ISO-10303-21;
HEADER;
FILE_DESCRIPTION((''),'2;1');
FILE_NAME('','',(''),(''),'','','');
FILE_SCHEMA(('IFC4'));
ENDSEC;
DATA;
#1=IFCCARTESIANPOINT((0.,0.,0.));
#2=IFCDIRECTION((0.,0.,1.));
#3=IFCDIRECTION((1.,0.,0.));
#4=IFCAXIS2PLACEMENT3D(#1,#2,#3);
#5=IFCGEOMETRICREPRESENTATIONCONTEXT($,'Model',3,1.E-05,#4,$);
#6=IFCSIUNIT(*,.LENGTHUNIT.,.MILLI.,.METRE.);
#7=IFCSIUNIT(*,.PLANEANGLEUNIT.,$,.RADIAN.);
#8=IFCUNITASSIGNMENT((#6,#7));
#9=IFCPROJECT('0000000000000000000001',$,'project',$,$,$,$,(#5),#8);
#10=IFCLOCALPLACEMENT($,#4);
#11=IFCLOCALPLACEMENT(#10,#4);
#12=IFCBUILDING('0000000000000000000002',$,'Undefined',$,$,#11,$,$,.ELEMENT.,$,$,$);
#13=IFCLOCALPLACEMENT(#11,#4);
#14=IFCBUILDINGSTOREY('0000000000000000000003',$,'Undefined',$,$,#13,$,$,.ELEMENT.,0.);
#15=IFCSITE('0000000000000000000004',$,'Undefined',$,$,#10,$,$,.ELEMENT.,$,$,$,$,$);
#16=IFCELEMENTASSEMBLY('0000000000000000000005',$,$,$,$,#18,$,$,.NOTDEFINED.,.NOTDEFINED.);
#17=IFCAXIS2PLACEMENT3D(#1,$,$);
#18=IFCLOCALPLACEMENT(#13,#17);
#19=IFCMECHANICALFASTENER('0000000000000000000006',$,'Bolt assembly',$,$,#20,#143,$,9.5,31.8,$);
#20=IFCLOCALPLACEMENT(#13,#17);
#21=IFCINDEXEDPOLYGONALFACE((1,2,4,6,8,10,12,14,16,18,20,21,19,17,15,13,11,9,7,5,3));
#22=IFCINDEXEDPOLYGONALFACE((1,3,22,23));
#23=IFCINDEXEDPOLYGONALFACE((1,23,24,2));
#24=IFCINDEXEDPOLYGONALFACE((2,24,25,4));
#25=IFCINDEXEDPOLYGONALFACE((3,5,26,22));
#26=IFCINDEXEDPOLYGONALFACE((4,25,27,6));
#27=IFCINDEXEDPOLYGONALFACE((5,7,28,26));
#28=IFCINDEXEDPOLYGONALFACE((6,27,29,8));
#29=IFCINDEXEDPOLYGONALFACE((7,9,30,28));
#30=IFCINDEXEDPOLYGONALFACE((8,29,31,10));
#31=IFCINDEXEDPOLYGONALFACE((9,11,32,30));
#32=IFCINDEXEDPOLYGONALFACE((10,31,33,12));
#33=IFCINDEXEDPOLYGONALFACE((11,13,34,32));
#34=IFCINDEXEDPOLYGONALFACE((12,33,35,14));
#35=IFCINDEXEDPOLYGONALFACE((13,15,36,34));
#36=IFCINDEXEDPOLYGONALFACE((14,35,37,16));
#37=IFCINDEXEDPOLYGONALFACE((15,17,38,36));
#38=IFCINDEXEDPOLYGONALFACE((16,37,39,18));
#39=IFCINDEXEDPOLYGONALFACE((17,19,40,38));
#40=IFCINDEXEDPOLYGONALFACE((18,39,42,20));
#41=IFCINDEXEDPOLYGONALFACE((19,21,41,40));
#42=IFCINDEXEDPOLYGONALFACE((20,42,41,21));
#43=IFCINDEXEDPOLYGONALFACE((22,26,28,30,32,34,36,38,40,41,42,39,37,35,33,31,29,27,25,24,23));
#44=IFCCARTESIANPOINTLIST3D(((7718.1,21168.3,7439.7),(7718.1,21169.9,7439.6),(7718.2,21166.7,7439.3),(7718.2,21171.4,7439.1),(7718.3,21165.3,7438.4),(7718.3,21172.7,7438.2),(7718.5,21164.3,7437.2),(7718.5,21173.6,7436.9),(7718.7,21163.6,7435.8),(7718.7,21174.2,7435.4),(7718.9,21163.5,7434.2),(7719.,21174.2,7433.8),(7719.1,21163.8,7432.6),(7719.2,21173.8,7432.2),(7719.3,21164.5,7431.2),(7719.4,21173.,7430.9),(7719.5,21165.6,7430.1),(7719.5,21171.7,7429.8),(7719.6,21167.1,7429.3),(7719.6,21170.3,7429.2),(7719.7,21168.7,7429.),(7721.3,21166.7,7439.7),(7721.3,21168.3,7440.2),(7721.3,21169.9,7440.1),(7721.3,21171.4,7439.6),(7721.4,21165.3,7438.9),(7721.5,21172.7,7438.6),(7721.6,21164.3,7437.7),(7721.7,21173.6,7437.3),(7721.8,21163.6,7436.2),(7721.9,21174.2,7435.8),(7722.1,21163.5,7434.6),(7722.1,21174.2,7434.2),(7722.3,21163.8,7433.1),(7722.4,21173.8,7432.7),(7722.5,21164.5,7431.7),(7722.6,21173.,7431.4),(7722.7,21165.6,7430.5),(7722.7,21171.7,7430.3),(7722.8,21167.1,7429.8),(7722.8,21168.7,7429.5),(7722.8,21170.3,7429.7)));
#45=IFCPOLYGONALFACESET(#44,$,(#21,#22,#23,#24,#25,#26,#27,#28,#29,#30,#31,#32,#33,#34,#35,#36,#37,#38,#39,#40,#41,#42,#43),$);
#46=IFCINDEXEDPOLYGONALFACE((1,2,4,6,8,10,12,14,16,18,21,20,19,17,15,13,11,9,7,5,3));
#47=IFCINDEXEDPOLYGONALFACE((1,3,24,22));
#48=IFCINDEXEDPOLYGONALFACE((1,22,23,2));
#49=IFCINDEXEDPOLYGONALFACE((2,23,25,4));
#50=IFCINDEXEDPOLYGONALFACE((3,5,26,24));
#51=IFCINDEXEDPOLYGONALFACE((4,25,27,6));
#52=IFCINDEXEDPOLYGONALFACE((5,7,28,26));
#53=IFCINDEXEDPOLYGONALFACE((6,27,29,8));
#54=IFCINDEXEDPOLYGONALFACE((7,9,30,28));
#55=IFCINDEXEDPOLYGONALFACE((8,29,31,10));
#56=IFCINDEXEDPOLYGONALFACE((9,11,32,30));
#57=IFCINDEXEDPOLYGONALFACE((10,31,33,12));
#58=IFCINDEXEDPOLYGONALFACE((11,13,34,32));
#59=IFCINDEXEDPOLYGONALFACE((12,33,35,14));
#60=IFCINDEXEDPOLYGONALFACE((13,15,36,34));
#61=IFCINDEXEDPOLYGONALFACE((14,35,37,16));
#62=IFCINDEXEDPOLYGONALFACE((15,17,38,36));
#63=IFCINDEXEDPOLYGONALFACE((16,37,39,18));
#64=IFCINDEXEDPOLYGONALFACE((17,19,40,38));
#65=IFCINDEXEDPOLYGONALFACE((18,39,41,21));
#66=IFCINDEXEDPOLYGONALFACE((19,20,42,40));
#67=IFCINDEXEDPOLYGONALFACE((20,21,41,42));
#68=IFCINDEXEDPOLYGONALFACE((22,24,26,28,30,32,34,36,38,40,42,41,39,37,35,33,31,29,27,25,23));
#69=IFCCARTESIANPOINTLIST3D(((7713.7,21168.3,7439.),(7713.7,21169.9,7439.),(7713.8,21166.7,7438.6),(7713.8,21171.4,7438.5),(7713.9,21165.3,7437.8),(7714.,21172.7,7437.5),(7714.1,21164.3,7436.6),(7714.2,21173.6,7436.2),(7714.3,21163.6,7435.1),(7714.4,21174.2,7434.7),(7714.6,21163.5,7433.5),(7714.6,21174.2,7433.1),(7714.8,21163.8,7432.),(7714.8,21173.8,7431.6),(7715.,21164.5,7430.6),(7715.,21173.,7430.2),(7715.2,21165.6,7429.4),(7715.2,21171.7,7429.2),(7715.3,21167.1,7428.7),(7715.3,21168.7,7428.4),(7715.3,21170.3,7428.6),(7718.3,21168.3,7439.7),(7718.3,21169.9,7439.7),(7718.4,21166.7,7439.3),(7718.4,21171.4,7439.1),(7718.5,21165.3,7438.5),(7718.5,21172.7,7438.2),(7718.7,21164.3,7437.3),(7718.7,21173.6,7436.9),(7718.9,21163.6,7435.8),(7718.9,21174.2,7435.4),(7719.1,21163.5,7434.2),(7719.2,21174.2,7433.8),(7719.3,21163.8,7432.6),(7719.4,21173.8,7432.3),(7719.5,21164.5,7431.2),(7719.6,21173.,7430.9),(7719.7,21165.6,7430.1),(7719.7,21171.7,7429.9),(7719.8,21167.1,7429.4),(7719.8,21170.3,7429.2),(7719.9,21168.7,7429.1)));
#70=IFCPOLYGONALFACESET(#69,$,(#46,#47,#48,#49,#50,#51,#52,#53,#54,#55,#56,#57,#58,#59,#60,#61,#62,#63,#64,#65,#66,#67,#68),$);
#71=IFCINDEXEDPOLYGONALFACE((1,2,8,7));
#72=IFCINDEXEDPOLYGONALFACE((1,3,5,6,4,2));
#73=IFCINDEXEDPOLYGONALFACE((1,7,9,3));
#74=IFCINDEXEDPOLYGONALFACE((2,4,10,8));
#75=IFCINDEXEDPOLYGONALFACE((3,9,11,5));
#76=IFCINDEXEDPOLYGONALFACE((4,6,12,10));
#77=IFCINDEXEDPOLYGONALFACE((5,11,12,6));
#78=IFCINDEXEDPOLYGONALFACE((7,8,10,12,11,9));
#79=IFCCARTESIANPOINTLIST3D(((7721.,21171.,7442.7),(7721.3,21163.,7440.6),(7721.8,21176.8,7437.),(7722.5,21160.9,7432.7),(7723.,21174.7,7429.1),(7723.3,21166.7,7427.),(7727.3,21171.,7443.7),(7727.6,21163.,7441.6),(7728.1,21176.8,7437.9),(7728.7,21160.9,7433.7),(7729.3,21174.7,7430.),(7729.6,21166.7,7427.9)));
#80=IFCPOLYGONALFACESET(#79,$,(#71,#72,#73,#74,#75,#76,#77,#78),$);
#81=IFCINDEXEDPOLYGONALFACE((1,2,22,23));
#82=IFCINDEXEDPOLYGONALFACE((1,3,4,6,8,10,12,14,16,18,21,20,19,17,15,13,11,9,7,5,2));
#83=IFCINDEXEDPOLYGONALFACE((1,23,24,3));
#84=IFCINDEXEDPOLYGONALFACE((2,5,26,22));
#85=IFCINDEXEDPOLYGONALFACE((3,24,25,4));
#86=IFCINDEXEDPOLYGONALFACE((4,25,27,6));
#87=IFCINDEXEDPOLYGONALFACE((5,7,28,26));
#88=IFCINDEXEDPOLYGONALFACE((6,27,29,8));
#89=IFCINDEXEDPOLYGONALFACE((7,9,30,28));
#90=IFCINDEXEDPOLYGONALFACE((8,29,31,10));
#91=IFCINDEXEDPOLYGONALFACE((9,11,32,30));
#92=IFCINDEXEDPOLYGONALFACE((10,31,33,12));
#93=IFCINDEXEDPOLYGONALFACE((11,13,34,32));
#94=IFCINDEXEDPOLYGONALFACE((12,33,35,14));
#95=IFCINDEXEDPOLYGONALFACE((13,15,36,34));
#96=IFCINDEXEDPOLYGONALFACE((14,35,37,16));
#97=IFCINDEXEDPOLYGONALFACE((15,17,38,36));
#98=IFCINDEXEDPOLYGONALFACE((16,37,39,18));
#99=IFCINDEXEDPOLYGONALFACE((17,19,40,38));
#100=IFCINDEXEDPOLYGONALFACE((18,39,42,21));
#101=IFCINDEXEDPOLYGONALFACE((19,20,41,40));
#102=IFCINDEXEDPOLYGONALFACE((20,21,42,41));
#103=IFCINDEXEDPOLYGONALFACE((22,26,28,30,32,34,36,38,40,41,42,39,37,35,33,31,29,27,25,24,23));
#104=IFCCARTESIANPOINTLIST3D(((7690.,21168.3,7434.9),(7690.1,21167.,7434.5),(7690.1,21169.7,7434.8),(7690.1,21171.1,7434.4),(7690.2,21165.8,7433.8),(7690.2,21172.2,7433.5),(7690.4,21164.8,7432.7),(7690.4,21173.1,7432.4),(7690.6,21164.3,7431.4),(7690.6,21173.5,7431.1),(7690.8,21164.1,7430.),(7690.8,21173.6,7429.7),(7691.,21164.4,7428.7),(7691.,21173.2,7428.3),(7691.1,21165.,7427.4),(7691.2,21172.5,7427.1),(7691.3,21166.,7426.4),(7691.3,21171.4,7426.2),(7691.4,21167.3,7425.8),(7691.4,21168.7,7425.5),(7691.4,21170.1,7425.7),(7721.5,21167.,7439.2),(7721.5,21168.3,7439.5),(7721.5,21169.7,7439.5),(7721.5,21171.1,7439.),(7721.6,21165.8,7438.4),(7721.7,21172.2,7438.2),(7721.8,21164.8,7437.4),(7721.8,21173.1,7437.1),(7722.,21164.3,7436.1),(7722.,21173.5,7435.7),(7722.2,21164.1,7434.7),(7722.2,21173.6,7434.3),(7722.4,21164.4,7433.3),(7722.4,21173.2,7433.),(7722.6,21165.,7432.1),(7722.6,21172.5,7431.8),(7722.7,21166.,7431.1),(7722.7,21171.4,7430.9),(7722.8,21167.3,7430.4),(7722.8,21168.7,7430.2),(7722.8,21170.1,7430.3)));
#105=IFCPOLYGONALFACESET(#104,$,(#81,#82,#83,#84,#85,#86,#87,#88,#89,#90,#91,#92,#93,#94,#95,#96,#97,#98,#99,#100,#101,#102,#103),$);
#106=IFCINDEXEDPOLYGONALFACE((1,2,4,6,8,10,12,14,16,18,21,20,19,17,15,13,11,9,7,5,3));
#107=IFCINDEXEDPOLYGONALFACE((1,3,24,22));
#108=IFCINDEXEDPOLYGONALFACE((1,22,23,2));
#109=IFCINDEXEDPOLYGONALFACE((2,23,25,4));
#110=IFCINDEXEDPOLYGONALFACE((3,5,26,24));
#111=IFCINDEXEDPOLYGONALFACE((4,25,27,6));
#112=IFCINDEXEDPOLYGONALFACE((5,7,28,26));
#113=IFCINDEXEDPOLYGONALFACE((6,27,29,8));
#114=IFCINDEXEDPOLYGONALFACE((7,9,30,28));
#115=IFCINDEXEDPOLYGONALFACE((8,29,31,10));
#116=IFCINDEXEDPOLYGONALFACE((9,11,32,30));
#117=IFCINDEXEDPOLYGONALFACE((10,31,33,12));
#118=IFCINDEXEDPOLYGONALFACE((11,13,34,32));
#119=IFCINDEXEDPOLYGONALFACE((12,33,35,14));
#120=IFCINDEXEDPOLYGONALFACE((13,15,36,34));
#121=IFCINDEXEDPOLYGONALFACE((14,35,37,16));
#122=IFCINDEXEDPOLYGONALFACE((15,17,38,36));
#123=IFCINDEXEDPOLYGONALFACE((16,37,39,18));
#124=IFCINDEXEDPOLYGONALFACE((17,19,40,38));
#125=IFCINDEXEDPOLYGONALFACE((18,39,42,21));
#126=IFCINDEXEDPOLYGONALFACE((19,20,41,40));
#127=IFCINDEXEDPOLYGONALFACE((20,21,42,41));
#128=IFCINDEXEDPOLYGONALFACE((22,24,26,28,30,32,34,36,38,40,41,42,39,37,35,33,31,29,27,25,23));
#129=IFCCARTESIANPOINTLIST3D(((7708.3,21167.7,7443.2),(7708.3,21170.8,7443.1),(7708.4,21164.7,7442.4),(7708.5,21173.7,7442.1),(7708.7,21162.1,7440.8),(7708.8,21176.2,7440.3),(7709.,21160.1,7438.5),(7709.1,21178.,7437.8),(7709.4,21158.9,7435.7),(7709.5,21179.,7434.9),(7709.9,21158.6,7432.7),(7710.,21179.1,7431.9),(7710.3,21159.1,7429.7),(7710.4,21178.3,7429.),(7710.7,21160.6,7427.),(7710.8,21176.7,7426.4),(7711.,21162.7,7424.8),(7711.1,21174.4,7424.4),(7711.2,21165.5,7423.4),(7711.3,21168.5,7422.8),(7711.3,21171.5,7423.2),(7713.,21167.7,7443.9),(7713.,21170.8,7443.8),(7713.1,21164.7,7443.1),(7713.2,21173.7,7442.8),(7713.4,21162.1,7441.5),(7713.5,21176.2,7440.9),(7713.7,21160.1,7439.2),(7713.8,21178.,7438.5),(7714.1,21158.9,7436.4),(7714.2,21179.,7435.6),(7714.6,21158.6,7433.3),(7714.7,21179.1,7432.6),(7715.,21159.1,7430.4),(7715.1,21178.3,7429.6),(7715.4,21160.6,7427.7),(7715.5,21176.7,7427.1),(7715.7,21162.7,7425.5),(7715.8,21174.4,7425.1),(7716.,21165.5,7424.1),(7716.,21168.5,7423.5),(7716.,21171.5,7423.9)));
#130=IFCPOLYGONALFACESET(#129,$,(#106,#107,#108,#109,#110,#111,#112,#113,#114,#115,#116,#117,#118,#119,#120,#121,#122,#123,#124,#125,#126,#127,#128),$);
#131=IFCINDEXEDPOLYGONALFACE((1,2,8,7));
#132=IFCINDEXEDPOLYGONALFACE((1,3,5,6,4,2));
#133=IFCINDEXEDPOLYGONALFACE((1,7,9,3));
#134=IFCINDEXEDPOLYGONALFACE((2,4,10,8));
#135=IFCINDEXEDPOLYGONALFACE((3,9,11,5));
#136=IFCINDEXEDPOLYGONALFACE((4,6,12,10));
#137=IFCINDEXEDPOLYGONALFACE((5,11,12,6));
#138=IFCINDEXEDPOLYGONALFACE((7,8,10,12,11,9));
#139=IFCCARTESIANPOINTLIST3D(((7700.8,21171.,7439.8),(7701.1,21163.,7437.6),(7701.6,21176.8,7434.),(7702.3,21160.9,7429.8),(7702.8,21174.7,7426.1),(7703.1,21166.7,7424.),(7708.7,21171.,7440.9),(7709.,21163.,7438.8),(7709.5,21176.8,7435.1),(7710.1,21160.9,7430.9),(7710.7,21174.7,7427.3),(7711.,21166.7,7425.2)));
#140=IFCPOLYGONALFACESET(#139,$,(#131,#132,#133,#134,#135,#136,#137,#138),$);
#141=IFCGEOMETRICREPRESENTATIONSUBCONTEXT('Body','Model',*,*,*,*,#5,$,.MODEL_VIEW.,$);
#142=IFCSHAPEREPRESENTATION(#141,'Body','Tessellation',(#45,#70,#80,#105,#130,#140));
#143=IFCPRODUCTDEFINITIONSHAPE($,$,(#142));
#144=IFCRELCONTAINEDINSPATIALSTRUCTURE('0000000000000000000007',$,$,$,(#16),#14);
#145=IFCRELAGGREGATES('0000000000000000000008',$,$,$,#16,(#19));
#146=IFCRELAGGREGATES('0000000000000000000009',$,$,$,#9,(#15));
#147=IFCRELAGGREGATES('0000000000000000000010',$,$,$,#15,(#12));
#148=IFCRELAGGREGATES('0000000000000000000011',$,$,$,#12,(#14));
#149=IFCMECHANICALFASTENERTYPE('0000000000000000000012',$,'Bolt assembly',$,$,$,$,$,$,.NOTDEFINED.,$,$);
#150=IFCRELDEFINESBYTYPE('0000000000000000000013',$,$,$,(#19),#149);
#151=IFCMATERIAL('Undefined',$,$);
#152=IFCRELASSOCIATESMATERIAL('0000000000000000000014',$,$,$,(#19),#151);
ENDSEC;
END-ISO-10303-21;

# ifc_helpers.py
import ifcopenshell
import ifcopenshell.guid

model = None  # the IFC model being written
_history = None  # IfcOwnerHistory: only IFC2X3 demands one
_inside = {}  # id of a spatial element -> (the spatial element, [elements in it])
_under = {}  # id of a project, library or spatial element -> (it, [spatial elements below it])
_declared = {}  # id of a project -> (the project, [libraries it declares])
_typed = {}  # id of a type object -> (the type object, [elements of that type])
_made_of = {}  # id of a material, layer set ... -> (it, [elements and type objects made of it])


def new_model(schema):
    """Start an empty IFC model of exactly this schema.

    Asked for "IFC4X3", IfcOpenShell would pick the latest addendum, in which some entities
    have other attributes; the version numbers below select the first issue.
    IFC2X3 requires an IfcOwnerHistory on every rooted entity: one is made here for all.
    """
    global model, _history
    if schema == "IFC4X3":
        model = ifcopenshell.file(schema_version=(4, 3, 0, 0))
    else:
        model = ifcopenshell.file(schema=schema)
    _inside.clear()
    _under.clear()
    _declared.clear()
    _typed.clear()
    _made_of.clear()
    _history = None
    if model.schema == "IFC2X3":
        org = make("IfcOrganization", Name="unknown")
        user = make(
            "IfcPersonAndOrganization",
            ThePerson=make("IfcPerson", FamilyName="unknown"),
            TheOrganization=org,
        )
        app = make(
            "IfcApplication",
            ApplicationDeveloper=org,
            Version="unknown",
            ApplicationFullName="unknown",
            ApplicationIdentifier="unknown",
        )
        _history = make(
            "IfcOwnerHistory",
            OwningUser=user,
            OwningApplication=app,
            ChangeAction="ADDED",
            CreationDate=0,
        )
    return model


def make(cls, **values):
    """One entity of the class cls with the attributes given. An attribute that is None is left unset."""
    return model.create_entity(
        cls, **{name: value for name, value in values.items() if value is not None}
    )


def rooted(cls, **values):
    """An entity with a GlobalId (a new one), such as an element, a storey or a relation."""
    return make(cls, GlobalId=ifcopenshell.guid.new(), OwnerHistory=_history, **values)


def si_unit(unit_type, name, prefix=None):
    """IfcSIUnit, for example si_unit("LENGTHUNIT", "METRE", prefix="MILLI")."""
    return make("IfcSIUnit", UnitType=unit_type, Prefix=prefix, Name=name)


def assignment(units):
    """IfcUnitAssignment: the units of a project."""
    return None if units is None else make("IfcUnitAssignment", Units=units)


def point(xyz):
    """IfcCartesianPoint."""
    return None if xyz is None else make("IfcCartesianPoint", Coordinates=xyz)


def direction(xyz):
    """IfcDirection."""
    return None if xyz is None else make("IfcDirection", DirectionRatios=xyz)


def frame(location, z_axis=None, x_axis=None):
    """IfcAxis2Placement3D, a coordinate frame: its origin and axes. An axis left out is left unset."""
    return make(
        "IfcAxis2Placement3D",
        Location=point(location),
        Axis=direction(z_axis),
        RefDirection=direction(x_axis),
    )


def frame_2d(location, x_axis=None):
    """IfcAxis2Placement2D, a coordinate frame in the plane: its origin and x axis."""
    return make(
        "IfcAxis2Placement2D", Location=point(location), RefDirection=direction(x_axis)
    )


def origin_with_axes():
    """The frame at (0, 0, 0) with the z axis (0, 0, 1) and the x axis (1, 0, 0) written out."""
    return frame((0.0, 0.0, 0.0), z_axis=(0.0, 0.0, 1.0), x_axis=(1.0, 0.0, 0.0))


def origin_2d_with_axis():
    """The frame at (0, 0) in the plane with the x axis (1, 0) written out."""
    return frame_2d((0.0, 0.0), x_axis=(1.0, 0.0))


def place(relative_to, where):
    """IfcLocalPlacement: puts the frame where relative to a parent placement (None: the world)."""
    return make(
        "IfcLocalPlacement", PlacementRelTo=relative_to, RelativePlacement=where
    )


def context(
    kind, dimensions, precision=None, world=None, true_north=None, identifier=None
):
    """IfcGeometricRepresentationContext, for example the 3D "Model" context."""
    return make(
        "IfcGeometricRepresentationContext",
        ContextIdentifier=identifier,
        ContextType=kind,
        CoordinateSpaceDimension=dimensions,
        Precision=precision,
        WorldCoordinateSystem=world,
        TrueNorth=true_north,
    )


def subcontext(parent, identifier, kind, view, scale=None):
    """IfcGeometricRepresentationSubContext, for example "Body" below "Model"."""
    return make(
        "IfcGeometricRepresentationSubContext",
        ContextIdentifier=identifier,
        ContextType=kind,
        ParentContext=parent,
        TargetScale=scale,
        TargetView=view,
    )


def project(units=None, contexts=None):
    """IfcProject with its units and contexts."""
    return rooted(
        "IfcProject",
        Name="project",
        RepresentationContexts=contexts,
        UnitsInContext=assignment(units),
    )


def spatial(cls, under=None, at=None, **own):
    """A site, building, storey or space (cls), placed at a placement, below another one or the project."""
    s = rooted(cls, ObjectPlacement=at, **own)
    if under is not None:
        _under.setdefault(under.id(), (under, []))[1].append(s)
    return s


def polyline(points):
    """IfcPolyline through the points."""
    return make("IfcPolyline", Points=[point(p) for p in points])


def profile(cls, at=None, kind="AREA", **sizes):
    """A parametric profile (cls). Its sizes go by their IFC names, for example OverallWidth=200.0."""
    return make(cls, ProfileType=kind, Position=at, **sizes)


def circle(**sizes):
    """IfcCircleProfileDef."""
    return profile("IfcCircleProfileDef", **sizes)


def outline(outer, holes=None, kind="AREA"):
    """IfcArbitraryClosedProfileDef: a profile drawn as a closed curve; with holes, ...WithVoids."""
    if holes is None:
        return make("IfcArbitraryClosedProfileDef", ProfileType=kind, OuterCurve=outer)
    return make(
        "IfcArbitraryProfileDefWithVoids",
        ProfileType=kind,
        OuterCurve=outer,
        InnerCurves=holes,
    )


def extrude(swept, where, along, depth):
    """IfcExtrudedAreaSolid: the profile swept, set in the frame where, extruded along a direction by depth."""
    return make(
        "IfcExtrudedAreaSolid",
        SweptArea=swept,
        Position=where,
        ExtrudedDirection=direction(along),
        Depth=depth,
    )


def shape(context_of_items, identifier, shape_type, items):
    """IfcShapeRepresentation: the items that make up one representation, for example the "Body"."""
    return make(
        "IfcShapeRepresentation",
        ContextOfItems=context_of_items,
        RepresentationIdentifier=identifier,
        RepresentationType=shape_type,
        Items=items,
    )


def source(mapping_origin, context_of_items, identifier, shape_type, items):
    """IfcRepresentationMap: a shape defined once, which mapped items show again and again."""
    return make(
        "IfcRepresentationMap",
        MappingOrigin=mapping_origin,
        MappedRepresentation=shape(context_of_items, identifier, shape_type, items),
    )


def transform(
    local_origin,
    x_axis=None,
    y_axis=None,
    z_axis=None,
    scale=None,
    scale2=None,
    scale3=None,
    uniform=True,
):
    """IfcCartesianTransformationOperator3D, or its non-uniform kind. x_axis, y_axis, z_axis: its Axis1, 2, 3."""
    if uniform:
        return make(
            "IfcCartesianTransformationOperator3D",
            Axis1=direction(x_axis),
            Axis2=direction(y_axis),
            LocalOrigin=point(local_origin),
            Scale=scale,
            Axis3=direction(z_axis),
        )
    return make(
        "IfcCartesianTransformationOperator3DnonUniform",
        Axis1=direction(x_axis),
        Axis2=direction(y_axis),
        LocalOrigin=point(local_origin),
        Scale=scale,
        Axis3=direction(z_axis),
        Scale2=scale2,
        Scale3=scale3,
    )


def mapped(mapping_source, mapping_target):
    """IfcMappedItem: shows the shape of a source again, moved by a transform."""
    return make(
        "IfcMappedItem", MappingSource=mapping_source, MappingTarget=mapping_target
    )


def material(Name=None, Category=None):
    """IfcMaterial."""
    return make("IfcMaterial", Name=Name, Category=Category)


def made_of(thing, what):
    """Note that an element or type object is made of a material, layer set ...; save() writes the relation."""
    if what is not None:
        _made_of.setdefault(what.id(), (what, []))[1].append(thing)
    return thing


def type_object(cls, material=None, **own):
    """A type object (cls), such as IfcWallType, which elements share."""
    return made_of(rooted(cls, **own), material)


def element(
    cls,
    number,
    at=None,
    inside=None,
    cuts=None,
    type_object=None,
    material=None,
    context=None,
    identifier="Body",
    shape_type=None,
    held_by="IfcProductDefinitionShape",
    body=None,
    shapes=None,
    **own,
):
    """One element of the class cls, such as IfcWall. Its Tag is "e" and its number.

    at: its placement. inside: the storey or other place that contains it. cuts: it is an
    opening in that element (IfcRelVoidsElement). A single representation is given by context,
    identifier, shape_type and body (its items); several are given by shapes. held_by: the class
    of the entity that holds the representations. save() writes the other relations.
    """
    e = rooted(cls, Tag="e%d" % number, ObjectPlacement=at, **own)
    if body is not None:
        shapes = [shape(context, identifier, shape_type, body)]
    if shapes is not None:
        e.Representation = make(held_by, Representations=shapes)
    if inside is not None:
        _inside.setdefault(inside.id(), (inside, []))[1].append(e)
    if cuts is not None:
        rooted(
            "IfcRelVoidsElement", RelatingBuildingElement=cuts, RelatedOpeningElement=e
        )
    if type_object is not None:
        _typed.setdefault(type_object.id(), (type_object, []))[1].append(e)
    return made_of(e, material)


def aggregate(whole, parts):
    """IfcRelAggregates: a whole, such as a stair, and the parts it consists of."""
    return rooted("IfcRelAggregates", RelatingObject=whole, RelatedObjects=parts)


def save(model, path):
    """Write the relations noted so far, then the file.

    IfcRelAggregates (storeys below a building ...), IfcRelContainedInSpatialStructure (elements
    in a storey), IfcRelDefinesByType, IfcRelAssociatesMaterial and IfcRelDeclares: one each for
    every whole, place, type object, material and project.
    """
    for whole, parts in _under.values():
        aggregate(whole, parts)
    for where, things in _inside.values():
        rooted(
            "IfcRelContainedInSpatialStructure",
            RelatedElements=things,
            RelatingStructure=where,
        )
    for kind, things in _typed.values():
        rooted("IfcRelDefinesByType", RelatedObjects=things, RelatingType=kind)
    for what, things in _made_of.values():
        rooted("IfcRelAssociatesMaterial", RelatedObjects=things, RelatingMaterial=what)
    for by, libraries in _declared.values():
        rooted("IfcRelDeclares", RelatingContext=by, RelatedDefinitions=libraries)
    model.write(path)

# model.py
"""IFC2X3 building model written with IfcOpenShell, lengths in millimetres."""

from ifc_helpers import new_model, si_unit, frame, origin_with_axes, origin_2d_with_axis, place, context, subcontext, project, spatial, polyline, circle, outline, extrude, source, transform, mapped, material, type_object, element, aggregate, save


model = new_model("IFC2X3")

# Units and contexts
model_context = context("Model", 3, precision=1e-05, world=origin_with_axes())
body_context = subcontext(model_context, "Body", "Model", "MODEL_VIEW")
ifc_project = project(units=[si_unit("LENGTHUNIT", "METRE", prefix="MILLI"), si_unit("PLANEANGLEUNIT", "RADIAN")], contexts=[model_context])

# Site, building, storey
site_placement = place(None, origin_with_axes())
site = spatial("IfcSite", under=ifc_project, at=site_placement, Name="Undefined", CompositionType="ELEMENT")
building_placement = place(site_placement, origin_with_axes())
building = spatial("IfcBuilding", under=site, at=building_placement, Name="Undefined", CompositionType="ELEMENT")
storey_placement = place(building_placement, origin_with_axes())
storey = spatial("IfcBuildingStorey", under=building, at=storey_placement, Name="Undefined", CompositionType="ELEMENT", Elevation=0.0)

# Element assembly
assembly_1_placement = place(storey_placement, origin_with_axes())
assembly_1 = element("IfcElementAssembly", 1, at=assembly_1_placement, inside=storey, AssemblyPlace="NOTDEFINED", PredefinedType="NOTDEFINED")

# Shared definitions
ifc_material_1 = material(Name="Undefined")
mechanical_fastener_type = type_object("IfcMechanicalFastenerType", Name="Bolt assembly")

# Mechanical fastener
shared_shape_1 = source(origin_with_axes(), body_context, "Body", "SweptSolid", [
    extrude(circle(Radius=5.4, at=origin_2d_with_axis()), frame((0.0, -3.1, 0.0), z_axis=(0.0, 1.0, 0.0), x_axis=(1.0, 0.0, 0.0)), (0.0, 0.0, 1.0), 3.2),
    extrude(circle(Radius=5.4, at=origin_2d_with_axis()), frame((0.0, -0.1, 0.0), z_axis=(0.0, 1.0, 0.0), x_axis=(1.0, 0.0, 0.0)), (0.0, 0.0, 1.0), 4.6),
    extrude(outline(polyline([(7.1, -4.1), (7.1, 4.1), (0.0, 8.2), (-7.1, 4.1), (-7.1, -4.1), (0.0, -8.2), (7.1, -4.1)])), frame((0.0, -9.6, 0.0), z_axis=(0.0, 1.0, 0.0), x_axis=(1.0, 0.0, 0.0)), (0.0, 0.0, 1.0), 6.3),
    extrude(circle(Radius=4.8, at=origin_2d_with_axis()), frame((0.0, -3.2, 0.0), z_axis=(0.0, 1.0, 0.0), x_axis=(1.0, 0.0, 0.0)), (0.0, 0.0, 1.0), 31.8),
    extrude(circle(Radius=10.3, at=origin_2d_with_axis()), frame((0.0, 4.5, 0.0), z_axis=(0.0, 1.0, 0.0), x_axis=(1.0, 0.0, 0.0)), (0.0, 0.0, 1.0), 4.8),
    extrude(outline(polyline([(7.1, -4.1), (7.1, 4.1), (0.0, 8.2), (-7.1, 4.1), (-7.1, -4.1), (0.0, -8.2), (7.1, -4.1)])), frame((0.0, 9.3, 0.0), z_axis=(0.0, 1.0, 0.0), x_axis=(1.0, 0.0, 0.0)), (0.0, 0.0, 1.0), 7.9),
])
mechanical_fastener_1_placement = place(assembly_1_placement, frame((7719.0, 21168.9, 7434.4), z_axis=(-0.103381, -0.707107, 0.699509), x_axis=(-0.103381, 0.707107, 0.699509)))
mechanical_fastener_1 = element("IfcMechanicalFastener", 2, at=mechanical_fastener_1_placement, type_object=mechanical_fastener_type, material=ifc_material_1, Name="Bolt assembly", NominalDiameter=9.5, NominalLength=31.8, context=body_context, shape_type="MappedRepresentation", body=[
    mapped(shared_shape_1, transform((0.0, 0.0, 0.0))),
])
aggregate(assembly_1, [mechanical_fastener_1])

save(model, "model.ifc")
